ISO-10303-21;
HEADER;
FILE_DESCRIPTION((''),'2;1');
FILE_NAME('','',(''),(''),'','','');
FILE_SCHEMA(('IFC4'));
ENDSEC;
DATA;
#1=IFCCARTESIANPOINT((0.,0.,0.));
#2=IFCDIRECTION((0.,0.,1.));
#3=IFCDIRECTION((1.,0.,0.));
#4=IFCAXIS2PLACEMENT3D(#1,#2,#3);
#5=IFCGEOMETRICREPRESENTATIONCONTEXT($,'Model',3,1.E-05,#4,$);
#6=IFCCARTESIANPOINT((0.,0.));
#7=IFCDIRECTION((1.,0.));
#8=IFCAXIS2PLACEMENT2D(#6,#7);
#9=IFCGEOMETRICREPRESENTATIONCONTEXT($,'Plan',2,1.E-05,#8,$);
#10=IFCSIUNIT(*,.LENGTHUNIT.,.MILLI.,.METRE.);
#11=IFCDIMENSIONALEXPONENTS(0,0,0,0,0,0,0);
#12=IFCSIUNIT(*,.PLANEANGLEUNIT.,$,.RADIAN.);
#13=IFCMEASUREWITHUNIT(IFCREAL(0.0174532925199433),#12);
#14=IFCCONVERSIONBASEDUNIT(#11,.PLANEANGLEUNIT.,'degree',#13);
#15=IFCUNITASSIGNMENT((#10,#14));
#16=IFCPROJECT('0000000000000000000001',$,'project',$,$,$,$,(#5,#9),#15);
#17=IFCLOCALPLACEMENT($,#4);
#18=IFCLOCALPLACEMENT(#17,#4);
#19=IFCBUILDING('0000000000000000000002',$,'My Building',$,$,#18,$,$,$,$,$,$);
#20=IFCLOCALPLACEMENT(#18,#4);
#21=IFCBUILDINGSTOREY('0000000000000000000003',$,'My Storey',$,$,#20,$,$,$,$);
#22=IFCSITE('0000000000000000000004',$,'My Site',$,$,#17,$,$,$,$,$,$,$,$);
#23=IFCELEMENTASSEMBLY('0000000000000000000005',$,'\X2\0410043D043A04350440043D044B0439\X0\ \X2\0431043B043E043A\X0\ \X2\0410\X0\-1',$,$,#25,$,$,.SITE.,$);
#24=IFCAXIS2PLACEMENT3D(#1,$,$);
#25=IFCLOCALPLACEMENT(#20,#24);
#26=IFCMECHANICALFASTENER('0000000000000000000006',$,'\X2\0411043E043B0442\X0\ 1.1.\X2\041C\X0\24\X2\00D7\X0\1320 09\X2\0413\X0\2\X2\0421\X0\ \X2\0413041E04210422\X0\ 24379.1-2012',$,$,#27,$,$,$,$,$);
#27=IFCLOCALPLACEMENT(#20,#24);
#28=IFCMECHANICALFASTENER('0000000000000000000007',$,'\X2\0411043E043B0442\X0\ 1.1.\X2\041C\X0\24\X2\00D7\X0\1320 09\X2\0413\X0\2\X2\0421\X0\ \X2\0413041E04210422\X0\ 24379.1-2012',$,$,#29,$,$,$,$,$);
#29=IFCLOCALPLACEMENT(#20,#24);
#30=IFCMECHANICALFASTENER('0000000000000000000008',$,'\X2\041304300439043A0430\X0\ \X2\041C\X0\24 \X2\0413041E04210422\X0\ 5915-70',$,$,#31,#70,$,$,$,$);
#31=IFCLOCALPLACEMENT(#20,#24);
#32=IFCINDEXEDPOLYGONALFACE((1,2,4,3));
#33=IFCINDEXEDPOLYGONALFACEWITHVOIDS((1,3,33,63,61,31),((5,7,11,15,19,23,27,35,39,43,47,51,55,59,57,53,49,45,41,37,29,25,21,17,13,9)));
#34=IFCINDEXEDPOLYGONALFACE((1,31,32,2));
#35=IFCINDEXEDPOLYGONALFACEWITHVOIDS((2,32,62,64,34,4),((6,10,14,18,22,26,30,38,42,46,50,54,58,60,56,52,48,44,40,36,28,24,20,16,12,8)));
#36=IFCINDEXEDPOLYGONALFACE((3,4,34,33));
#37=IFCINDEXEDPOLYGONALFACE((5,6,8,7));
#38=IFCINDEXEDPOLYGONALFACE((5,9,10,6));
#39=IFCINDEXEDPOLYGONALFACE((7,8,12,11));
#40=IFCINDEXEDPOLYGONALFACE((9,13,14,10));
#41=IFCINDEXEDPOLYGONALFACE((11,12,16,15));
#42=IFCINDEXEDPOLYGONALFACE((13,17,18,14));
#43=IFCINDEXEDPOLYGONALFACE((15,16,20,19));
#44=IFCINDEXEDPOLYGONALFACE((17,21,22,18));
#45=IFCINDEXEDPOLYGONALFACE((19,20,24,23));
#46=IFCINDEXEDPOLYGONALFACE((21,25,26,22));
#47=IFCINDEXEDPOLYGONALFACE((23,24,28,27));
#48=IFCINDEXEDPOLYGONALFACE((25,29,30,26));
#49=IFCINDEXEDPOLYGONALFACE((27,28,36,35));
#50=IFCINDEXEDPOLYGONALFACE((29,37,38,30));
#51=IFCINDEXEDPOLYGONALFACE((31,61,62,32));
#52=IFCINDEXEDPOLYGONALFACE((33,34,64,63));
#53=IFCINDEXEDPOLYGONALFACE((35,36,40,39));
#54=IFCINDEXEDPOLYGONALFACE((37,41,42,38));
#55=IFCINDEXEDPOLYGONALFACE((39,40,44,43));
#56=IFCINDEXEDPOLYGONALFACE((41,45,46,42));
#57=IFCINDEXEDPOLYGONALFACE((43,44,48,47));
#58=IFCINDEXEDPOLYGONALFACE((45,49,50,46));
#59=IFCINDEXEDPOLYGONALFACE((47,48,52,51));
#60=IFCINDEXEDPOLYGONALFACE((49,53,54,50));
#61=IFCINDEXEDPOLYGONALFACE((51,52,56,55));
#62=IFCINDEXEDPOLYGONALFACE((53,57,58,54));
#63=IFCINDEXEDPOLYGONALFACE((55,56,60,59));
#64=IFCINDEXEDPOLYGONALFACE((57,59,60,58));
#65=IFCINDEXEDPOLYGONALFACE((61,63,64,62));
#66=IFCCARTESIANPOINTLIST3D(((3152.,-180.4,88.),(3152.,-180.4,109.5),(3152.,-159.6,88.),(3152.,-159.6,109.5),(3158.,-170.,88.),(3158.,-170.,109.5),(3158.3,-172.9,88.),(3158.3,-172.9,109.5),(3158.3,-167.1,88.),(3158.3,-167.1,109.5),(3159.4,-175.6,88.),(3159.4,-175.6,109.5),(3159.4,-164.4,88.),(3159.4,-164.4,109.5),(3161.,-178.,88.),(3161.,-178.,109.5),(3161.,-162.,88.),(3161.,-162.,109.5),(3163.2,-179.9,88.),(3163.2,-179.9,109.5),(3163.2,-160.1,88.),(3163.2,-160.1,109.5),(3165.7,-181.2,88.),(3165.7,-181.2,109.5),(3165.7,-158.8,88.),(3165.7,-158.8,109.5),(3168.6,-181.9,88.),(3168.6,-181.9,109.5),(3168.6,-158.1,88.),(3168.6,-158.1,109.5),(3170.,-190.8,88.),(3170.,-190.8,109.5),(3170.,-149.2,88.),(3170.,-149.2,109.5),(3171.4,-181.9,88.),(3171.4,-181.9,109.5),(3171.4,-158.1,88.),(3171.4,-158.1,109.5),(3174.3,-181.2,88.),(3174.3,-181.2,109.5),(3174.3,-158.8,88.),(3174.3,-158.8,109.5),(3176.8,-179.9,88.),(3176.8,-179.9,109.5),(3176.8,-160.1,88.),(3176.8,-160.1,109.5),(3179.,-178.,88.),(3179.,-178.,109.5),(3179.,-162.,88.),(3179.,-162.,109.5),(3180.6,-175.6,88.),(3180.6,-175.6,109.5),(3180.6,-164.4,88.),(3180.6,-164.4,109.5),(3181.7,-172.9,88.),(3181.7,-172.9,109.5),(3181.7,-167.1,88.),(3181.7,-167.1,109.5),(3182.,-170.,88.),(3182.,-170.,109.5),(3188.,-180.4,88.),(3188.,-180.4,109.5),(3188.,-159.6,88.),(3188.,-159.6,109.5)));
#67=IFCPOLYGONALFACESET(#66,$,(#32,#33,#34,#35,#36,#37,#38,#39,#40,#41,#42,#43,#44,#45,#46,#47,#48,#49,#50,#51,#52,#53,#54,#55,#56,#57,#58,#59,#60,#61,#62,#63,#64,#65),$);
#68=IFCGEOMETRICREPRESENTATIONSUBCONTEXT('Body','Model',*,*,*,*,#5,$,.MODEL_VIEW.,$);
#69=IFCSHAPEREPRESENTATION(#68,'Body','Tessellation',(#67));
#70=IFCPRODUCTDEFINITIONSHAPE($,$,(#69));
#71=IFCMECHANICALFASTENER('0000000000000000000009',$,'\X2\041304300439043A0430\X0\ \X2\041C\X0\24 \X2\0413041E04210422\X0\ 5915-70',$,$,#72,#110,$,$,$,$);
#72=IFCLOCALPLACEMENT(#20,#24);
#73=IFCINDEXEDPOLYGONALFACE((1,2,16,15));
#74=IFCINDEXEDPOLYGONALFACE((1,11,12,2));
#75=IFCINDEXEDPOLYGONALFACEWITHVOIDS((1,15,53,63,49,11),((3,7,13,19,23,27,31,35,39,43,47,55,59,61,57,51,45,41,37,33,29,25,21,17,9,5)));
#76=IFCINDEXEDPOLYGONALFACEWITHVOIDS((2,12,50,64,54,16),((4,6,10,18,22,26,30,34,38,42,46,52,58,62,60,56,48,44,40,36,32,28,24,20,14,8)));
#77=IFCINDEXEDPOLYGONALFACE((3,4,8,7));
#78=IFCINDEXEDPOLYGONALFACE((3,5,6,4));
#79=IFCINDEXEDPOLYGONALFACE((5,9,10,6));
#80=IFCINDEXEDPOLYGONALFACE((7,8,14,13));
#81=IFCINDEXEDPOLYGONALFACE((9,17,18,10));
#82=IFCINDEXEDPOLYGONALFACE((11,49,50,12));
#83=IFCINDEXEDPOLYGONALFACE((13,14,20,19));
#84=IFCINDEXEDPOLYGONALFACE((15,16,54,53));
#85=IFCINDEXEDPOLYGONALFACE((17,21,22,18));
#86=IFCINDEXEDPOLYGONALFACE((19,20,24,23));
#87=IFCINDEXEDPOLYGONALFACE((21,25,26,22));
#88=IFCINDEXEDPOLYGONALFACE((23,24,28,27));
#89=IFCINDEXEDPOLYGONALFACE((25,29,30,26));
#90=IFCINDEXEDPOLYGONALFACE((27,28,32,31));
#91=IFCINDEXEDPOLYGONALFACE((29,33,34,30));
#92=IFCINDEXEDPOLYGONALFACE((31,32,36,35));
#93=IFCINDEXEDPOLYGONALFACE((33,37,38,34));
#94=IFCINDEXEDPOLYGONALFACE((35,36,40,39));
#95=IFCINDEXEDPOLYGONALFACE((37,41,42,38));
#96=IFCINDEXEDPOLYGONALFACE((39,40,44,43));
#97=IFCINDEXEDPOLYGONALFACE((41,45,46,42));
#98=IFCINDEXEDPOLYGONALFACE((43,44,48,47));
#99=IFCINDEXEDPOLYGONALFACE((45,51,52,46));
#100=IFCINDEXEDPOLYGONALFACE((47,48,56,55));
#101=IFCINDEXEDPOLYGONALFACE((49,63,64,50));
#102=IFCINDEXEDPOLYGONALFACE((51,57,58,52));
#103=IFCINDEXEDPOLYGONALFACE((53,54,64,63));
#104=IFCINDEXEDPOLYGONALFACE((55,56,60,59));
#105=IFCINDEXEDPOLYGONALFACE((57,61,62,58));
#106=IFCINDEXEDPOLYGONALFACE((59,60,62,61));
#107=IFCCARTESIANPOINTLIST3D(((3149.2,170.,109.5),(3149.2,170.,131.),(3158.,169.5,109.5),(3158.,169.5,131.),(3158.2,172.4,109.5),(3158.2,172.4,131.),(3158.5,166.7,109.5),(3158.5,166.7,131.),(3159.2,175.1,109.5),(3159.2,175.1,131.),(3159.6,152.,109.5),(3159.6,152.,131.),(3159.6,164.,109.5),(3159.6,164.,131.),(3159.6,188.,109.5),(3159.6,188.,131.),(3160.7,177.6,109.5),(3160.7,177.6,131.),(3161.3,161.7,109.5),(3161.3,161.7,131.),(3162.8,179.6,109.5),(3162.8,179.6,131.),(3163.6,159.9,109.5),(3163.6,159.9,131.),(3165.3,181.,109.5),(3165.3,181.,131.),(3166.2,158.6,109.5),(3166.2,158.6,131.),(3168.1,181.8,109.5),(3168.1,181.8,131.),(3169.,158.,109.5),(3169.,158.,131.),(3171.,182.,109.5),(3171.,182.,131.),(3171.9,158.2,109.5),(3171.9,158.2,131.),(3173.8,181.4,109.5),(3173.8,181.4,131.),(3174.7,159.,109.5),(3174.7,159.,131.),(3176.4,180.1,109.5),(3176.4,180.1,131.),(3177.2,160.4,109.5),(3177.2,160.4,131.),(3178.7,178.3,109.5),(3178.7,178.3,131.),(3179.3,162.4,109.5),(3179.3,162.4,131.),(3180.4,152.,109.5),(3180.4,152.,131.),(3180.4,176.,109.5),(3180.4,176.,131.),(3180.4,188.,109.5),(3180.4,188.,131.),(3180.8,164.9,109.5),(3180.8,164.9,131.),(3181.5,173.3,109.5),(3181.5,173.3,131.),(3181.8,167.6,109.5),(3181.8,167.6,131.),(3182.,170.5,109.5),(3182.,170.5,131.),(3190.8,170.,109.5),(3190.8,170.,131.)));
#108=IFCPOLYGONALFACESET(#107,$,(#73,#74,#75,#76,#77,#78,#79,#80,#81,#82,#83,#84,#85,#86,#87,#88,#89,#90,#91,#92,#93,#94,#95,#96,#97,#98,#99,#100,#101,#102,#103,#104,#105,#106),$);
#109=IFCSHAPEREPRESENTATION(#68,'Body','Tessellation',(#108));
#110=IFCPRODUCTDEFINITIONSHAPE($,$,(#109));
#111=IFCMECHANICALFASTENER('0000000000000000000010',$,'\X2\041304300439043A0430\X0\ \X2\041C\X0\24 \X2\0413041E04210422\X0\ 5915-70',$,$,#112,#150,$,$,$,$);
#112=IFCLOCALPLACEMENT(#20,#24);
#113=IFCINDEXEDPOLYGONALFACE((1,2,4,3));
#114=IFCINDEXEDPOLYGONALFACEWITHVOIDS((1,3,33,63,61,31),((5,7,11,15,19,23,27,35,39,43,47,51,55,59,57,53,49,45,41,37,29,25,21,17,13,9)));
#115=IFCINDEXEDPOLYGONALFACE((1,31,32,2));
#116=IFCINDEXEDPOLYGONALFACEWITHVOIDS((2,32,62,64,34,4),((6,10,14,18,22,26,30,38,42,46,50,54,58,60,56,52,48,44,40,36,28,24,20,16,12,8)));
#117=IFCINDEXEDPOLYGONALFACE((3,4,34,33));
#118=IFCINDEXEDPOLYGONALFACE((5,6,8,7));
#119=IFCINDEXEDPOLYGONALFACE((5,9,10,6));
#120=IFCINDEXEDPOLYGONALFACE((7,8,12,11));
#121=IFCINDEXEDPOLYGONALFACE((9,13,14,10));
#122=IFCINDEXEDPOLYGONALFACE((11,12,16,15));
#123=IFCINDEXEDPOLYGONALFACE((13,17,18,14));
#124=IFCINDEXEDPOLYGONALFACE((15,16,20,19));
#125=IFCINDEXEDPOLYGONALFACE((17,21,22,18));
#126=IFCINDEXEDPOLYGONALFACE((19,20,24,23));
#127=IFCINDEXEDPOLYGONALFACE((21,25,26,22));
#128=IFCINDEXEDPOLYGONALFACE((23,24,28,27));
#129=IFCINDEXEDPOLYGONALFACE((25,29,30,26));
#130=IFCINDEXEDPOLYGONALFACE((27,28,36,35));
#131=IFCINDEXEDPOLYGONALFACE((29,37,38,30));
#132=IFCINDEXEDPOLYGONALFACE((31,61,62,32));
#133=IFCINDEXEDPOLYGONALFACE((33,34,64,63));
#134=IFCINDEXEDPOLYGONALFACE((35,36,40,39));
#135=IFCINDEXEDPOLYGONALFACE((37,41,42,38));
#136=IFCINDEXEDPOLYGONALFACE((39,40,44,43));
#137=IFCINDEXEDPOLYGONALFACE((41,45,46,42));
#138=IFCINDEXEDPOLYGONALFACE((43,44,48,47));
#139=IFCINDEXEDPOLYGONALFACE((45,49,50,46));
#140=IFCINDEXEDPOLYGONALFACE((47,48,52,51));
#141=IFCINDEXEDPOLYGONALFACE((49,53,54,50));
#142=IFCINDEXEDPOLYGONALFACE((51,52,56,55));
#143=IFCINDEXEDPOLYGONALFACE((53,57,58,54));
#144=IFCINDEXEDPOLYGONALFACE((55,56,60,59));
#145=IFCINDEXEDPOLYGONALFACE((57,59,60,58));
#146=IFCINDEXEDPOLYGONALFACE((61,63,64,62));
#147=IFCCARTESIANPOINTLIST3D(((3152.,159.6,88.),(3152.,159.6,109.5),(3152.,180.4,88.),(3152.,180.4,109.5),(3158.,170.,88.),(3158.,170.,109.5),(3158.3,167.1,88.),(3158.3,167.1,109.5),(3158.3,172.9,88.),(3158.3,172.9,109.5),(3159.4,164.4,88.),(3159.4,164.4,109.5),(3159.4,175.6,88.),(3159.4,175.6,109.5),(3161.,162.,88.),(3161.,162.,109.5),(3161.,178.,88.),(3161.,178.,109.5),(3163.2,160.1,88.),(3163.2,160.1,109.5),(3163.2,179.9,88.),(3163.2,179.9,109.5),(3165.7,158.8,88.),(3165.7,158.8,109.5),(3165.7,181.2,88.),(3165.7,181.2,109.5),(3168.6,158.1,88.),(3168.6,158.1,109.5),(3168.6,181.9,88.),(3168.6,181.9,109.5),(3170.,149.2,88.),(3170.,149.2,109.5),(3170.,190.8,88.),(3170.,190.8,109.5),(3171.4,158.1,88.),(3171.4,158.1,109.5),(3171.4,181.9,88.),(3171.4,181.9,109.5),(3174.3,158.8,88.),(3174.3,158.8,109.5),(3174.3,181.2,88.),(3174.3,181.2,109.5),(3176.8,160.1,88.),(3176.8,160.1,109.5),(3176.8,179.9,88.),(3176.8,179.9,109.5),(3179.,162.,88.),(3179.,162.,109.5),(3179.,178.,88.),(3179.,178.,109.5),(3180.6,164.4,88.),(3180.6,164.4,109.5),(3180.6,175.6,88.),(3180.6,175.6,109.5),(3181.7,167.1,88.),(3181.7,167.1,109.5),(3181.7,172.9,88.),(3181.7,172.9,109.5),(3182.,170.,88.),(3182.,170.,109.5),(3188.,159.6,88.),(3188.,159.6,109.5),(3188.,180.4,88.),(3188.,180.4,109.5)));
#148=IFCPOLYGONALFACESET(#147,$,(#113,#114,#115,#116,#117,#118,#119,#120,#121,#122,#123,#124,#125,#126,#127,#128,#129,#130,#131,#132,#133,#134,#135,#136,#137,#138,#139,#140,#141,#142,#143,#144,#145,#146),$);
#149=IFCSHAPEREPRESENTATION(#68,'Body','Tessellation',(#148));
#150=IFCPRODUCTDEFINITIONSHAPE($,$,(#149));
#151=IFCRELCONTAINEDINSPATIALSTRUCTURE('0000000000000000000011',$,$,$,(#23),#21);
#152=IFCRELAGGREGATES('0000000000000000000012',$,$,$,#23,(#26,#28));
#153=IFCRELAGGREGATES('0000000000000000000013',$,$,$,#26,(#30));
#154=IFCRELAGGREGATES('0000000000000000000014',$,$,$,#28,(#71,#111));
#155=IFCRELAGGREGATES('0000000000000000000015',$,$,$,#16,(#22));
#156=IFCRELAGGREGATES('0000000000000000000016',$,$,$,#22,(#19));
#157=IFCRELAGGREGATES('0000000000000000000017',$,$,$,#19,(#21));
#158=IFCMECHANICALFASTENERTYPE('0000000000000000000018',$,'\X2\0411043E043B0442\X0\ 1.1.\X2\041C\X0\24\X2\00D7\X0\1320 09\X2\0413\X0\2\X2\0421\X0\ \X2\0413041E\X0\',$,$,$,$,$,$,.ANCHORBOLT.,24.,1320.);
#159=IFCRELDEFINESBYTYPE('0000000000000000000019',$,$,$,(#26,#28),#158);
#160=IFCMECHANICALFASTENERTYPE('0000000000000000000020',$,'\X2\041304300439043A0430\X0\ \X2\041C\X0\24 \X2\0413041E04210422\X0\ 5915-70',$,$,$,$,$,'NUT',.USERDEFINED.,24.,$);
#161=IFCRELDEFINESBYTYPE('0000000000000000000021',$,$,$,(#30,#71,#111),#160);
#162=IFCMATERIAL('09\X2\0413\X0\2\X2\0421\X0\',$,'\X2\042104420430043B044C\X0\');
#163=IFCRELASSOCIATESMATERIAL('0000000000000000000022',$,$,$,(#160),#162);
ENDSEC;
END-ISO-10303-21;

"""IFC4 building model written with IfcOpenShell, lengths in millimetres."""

from ifc_helpers import new_model, entity, si_unit, converted_unit, frame, origin_with_axes, origin_2d_with_axis, place, context, subcontext, project, spatial, polyline, outline, extrude, source, transform, mapped, material, type_object, type_shapes, element, aggregate, save


model = new_model("IFC4")

# Units and contexts
model_context = context("Model", 3, precision=1e-05, world=origin_with_axes())
plan_context = context("Plan", 2, precision=1e-05, world=origin_2d_with_axis())
body_context = subcontext(model_context, "Body", "Model", "MODEL_VIEW")
ifc_project = project(units=[si_unit("LENGTHUNIT", "METRE", prefix="MILLI"), converted_unit("PLANEANGLEUNIT", "degree", entity("IfcReal", 0.0174532925199433), si_unit("PLANEANGLEUNIT", "RADIAN"), dimensions=[0, 0, 0, 0, 0, 0, 0])], contexts=[model_context, plan_context])

# Site, building, storey
site_placement = place(None, origin_with_axes())
site = spatial("IfcSite", under=ifc_project, at=site_placement, Name="My Site")
building_placement = place(site_placement, origin_with_axes())
building = spatial("IfcBuilding", under=site, at=building_placement, Name="My Building")
storey_placement = place(building_placement, origin_with_axes())
storey = spatial("IfcBuildingStorey", under=building, at=storey_placement, Name="My Storey")

# Shared definitions
placement = place(storey_placement, frame((3000.0, 0.0, 0.0), z_axis=(0.0, 0.0, 1.0), x_axis=(1.0, 0.0, 0.0)))

# Element assembly, mechanical fasteners
assembly = element("IfcElementAssembly", 1, at=placement, inside=storey, Name="Анкерный блок А-1", AssemblyPlace="SITE")
mechanical_fastener_type_1 = type_object("IfcMechanicalFastenerType", Name="Болт 1.1.М24×1320 09Г2С ГО", NominalDiameter=24.0, NominalLength=1320.0, PredefinedType="ANCHORBOLT")
ifc_material_1 = material(Name="09Г2С", Category="Сталь")
mechanical_fastener_1_placement = place(placement, frame((170.0, -170.0, 0.0), z_axis=(0.0, 0.0, 1.0), x_axis=(1.0, 0.0, 0.0)))
mechanical_fastener_1 = element("IfcMechanicalFastener", 2, at=mechanical_fastener_1_placement, type_object=mechanical_fastener_type_1, Name="Болт 1.1.М24×1320 09Г2С ГОСТ 24379.1-2012")
mechanical_fastener_2_placement = place(placement, frame((170.0, 170.0, 0.0), z_axis=(0.0, 0.0, 1.0), x_axis=(-1.0, 0.0, 0.0)))
mechanical_fastener_2 = element("IfcMechanicalFastener", 3, at=mechanical_fastener_2_placement, type_object=mechanical_fastener_type_1, Name="Болт 1.1.М24×1320 09Г2С ГОСТ 24379.1-2012")
aggregate(assembly, [mechanical_fastener_1, mechanical_fastener_2])
mechanical_fastener_type_2 = type_object("IfcMechanicalFastenerType", Name="Гайка М24 ГОСТ 5915-70", ElementType="NUT", NominalDiameter=24.0, PredefinedType="USERDEFINED", material=ifc_material_1)
shared_shape_1 = source(origin_with_axes(), body_context, "Body", "SweptSolid", [
    extrude(outline(polyline([(-10.4, -18.0), (10.4, -18.0), (20.8, 0.0), (10.4, 18.0), (-10.4, 18.0), (-20.8, 0.0), (-10.4, -18.0)]), holes=[polyline([(-8.0, 9.0), (-5.6, 10.6), (-2.9, 11.7), (0.0, 12.0), (2.9, 11.7), (5.6, 10.6), (8.0, 9.0), (9.9, 6.8), (11.2, 4.3), (11.9, 1.4), (11.9, -1.4), (11.2, -4.3), (9.9, -6.8), (8.0, -9.0), (5.6, -10.6), (2.9, -11.7), (0.0, -12.0), (-2.9, -11.7), (-5.6, -10.6), (-8.0, -9.0), (-9.9, -6.8), (-11.2, -4.3), (-11.9, -1.4), (-11.9, 1.4), (-11.2, 4.3), (-9.9, 6.8), (-8.0, 9.0)])]), frame((0.0, 0.0, 0.0), z_axis=(0.0, 0.0, 1.0), x_axis=(0.0, 1.0, 0.0)), (0.0, 0.0, 1.0), 21.5),
])
type_shapes(mechanical_fastener_type_2, [shared_shape_1])
mechanical_fastener_3_placement = place(mechanical_fastener_1_placement, frame((0.0, 0.0, 88.0), z_axis=(0.0, 0.0, 1.0), x_axis=(1.0, 0.0, 0.0)))
mechanical_fastener_3 = element("IfcMechanicalFastener", 4, at=mechanical_fastener_3_placement, type_object=mechanical_fastener_type_2, Name="Гайка М24 ГОСТ 5915-70", context=body_context, shape_type="MappedRepresentation", body=[
    mapped(shared_shape_1, transform((0.0, 0.0, 0.0), x_axis=(1.0, 0.0, 0.0), y_axis=(0.0, 1.0, 0.0), z_axis=(0.0, 0.0, 1.0), scale=1.0)),
])
mechanical_fastener_4_placement = place(mechanical_fastener_2_placement, frame((0.0, 0.0, 109.5), z_axis=(0.0, 0.0, 1.0), x_axis=(0.866025, 0.5, 0.0)))
mechanical_fastener_4 = element("IfcMechanicalFastener", 5, at=mechanical_fastener_4_placement, type_object=mechanical_fastener_type_2, Name="Гайка М24 ГОСТ 5915-70", context=body_context, shape_type="MappedRepresentation", body=[
    mapped(shared_shape_1, transform((0.0, 0.0, 0.0), x_axis=(1.0, 0.0, 0.0), y_axis=(0.0, 1.0, 0.0), z_axis=(0.0, 0.0, 1.0), scale=1.0)),
])
mechanical_fastener_5_placement = place(mechanical_fastener_2_placement, frame((0.0, 0.0, 88.0), z_axis=(0.0, 0.0, 1.0), x_axis=(1.0, 0.0, 0.0)))
mechanical_fastener_5 = element("IfcMechanicalFastener", 6, at=mechanical_fastener_5_placement, type_object=mechanical_fastener_type_2, Name="Гайка М24 ГОСТ 5915-70", context=body_context, shape_type="MappedRepresentation", body=[
    mapped(shared_shape_1, transform((0.0, 0.0, 0.0), x_axis=(1.0, 0.0, 0.0), y_axis=(0.0, 1.0, 0.0), z_axis=(0.0, 0.0, 1.0), scale=1.0)),
])
aggregate(mechanical_fastener_1, [mechanical_fastener_3])
aggregate(mechanical_fastener_2, [mechanical_fastener_4, mechanical_fastener_5])

save(model, "model.ifc")
